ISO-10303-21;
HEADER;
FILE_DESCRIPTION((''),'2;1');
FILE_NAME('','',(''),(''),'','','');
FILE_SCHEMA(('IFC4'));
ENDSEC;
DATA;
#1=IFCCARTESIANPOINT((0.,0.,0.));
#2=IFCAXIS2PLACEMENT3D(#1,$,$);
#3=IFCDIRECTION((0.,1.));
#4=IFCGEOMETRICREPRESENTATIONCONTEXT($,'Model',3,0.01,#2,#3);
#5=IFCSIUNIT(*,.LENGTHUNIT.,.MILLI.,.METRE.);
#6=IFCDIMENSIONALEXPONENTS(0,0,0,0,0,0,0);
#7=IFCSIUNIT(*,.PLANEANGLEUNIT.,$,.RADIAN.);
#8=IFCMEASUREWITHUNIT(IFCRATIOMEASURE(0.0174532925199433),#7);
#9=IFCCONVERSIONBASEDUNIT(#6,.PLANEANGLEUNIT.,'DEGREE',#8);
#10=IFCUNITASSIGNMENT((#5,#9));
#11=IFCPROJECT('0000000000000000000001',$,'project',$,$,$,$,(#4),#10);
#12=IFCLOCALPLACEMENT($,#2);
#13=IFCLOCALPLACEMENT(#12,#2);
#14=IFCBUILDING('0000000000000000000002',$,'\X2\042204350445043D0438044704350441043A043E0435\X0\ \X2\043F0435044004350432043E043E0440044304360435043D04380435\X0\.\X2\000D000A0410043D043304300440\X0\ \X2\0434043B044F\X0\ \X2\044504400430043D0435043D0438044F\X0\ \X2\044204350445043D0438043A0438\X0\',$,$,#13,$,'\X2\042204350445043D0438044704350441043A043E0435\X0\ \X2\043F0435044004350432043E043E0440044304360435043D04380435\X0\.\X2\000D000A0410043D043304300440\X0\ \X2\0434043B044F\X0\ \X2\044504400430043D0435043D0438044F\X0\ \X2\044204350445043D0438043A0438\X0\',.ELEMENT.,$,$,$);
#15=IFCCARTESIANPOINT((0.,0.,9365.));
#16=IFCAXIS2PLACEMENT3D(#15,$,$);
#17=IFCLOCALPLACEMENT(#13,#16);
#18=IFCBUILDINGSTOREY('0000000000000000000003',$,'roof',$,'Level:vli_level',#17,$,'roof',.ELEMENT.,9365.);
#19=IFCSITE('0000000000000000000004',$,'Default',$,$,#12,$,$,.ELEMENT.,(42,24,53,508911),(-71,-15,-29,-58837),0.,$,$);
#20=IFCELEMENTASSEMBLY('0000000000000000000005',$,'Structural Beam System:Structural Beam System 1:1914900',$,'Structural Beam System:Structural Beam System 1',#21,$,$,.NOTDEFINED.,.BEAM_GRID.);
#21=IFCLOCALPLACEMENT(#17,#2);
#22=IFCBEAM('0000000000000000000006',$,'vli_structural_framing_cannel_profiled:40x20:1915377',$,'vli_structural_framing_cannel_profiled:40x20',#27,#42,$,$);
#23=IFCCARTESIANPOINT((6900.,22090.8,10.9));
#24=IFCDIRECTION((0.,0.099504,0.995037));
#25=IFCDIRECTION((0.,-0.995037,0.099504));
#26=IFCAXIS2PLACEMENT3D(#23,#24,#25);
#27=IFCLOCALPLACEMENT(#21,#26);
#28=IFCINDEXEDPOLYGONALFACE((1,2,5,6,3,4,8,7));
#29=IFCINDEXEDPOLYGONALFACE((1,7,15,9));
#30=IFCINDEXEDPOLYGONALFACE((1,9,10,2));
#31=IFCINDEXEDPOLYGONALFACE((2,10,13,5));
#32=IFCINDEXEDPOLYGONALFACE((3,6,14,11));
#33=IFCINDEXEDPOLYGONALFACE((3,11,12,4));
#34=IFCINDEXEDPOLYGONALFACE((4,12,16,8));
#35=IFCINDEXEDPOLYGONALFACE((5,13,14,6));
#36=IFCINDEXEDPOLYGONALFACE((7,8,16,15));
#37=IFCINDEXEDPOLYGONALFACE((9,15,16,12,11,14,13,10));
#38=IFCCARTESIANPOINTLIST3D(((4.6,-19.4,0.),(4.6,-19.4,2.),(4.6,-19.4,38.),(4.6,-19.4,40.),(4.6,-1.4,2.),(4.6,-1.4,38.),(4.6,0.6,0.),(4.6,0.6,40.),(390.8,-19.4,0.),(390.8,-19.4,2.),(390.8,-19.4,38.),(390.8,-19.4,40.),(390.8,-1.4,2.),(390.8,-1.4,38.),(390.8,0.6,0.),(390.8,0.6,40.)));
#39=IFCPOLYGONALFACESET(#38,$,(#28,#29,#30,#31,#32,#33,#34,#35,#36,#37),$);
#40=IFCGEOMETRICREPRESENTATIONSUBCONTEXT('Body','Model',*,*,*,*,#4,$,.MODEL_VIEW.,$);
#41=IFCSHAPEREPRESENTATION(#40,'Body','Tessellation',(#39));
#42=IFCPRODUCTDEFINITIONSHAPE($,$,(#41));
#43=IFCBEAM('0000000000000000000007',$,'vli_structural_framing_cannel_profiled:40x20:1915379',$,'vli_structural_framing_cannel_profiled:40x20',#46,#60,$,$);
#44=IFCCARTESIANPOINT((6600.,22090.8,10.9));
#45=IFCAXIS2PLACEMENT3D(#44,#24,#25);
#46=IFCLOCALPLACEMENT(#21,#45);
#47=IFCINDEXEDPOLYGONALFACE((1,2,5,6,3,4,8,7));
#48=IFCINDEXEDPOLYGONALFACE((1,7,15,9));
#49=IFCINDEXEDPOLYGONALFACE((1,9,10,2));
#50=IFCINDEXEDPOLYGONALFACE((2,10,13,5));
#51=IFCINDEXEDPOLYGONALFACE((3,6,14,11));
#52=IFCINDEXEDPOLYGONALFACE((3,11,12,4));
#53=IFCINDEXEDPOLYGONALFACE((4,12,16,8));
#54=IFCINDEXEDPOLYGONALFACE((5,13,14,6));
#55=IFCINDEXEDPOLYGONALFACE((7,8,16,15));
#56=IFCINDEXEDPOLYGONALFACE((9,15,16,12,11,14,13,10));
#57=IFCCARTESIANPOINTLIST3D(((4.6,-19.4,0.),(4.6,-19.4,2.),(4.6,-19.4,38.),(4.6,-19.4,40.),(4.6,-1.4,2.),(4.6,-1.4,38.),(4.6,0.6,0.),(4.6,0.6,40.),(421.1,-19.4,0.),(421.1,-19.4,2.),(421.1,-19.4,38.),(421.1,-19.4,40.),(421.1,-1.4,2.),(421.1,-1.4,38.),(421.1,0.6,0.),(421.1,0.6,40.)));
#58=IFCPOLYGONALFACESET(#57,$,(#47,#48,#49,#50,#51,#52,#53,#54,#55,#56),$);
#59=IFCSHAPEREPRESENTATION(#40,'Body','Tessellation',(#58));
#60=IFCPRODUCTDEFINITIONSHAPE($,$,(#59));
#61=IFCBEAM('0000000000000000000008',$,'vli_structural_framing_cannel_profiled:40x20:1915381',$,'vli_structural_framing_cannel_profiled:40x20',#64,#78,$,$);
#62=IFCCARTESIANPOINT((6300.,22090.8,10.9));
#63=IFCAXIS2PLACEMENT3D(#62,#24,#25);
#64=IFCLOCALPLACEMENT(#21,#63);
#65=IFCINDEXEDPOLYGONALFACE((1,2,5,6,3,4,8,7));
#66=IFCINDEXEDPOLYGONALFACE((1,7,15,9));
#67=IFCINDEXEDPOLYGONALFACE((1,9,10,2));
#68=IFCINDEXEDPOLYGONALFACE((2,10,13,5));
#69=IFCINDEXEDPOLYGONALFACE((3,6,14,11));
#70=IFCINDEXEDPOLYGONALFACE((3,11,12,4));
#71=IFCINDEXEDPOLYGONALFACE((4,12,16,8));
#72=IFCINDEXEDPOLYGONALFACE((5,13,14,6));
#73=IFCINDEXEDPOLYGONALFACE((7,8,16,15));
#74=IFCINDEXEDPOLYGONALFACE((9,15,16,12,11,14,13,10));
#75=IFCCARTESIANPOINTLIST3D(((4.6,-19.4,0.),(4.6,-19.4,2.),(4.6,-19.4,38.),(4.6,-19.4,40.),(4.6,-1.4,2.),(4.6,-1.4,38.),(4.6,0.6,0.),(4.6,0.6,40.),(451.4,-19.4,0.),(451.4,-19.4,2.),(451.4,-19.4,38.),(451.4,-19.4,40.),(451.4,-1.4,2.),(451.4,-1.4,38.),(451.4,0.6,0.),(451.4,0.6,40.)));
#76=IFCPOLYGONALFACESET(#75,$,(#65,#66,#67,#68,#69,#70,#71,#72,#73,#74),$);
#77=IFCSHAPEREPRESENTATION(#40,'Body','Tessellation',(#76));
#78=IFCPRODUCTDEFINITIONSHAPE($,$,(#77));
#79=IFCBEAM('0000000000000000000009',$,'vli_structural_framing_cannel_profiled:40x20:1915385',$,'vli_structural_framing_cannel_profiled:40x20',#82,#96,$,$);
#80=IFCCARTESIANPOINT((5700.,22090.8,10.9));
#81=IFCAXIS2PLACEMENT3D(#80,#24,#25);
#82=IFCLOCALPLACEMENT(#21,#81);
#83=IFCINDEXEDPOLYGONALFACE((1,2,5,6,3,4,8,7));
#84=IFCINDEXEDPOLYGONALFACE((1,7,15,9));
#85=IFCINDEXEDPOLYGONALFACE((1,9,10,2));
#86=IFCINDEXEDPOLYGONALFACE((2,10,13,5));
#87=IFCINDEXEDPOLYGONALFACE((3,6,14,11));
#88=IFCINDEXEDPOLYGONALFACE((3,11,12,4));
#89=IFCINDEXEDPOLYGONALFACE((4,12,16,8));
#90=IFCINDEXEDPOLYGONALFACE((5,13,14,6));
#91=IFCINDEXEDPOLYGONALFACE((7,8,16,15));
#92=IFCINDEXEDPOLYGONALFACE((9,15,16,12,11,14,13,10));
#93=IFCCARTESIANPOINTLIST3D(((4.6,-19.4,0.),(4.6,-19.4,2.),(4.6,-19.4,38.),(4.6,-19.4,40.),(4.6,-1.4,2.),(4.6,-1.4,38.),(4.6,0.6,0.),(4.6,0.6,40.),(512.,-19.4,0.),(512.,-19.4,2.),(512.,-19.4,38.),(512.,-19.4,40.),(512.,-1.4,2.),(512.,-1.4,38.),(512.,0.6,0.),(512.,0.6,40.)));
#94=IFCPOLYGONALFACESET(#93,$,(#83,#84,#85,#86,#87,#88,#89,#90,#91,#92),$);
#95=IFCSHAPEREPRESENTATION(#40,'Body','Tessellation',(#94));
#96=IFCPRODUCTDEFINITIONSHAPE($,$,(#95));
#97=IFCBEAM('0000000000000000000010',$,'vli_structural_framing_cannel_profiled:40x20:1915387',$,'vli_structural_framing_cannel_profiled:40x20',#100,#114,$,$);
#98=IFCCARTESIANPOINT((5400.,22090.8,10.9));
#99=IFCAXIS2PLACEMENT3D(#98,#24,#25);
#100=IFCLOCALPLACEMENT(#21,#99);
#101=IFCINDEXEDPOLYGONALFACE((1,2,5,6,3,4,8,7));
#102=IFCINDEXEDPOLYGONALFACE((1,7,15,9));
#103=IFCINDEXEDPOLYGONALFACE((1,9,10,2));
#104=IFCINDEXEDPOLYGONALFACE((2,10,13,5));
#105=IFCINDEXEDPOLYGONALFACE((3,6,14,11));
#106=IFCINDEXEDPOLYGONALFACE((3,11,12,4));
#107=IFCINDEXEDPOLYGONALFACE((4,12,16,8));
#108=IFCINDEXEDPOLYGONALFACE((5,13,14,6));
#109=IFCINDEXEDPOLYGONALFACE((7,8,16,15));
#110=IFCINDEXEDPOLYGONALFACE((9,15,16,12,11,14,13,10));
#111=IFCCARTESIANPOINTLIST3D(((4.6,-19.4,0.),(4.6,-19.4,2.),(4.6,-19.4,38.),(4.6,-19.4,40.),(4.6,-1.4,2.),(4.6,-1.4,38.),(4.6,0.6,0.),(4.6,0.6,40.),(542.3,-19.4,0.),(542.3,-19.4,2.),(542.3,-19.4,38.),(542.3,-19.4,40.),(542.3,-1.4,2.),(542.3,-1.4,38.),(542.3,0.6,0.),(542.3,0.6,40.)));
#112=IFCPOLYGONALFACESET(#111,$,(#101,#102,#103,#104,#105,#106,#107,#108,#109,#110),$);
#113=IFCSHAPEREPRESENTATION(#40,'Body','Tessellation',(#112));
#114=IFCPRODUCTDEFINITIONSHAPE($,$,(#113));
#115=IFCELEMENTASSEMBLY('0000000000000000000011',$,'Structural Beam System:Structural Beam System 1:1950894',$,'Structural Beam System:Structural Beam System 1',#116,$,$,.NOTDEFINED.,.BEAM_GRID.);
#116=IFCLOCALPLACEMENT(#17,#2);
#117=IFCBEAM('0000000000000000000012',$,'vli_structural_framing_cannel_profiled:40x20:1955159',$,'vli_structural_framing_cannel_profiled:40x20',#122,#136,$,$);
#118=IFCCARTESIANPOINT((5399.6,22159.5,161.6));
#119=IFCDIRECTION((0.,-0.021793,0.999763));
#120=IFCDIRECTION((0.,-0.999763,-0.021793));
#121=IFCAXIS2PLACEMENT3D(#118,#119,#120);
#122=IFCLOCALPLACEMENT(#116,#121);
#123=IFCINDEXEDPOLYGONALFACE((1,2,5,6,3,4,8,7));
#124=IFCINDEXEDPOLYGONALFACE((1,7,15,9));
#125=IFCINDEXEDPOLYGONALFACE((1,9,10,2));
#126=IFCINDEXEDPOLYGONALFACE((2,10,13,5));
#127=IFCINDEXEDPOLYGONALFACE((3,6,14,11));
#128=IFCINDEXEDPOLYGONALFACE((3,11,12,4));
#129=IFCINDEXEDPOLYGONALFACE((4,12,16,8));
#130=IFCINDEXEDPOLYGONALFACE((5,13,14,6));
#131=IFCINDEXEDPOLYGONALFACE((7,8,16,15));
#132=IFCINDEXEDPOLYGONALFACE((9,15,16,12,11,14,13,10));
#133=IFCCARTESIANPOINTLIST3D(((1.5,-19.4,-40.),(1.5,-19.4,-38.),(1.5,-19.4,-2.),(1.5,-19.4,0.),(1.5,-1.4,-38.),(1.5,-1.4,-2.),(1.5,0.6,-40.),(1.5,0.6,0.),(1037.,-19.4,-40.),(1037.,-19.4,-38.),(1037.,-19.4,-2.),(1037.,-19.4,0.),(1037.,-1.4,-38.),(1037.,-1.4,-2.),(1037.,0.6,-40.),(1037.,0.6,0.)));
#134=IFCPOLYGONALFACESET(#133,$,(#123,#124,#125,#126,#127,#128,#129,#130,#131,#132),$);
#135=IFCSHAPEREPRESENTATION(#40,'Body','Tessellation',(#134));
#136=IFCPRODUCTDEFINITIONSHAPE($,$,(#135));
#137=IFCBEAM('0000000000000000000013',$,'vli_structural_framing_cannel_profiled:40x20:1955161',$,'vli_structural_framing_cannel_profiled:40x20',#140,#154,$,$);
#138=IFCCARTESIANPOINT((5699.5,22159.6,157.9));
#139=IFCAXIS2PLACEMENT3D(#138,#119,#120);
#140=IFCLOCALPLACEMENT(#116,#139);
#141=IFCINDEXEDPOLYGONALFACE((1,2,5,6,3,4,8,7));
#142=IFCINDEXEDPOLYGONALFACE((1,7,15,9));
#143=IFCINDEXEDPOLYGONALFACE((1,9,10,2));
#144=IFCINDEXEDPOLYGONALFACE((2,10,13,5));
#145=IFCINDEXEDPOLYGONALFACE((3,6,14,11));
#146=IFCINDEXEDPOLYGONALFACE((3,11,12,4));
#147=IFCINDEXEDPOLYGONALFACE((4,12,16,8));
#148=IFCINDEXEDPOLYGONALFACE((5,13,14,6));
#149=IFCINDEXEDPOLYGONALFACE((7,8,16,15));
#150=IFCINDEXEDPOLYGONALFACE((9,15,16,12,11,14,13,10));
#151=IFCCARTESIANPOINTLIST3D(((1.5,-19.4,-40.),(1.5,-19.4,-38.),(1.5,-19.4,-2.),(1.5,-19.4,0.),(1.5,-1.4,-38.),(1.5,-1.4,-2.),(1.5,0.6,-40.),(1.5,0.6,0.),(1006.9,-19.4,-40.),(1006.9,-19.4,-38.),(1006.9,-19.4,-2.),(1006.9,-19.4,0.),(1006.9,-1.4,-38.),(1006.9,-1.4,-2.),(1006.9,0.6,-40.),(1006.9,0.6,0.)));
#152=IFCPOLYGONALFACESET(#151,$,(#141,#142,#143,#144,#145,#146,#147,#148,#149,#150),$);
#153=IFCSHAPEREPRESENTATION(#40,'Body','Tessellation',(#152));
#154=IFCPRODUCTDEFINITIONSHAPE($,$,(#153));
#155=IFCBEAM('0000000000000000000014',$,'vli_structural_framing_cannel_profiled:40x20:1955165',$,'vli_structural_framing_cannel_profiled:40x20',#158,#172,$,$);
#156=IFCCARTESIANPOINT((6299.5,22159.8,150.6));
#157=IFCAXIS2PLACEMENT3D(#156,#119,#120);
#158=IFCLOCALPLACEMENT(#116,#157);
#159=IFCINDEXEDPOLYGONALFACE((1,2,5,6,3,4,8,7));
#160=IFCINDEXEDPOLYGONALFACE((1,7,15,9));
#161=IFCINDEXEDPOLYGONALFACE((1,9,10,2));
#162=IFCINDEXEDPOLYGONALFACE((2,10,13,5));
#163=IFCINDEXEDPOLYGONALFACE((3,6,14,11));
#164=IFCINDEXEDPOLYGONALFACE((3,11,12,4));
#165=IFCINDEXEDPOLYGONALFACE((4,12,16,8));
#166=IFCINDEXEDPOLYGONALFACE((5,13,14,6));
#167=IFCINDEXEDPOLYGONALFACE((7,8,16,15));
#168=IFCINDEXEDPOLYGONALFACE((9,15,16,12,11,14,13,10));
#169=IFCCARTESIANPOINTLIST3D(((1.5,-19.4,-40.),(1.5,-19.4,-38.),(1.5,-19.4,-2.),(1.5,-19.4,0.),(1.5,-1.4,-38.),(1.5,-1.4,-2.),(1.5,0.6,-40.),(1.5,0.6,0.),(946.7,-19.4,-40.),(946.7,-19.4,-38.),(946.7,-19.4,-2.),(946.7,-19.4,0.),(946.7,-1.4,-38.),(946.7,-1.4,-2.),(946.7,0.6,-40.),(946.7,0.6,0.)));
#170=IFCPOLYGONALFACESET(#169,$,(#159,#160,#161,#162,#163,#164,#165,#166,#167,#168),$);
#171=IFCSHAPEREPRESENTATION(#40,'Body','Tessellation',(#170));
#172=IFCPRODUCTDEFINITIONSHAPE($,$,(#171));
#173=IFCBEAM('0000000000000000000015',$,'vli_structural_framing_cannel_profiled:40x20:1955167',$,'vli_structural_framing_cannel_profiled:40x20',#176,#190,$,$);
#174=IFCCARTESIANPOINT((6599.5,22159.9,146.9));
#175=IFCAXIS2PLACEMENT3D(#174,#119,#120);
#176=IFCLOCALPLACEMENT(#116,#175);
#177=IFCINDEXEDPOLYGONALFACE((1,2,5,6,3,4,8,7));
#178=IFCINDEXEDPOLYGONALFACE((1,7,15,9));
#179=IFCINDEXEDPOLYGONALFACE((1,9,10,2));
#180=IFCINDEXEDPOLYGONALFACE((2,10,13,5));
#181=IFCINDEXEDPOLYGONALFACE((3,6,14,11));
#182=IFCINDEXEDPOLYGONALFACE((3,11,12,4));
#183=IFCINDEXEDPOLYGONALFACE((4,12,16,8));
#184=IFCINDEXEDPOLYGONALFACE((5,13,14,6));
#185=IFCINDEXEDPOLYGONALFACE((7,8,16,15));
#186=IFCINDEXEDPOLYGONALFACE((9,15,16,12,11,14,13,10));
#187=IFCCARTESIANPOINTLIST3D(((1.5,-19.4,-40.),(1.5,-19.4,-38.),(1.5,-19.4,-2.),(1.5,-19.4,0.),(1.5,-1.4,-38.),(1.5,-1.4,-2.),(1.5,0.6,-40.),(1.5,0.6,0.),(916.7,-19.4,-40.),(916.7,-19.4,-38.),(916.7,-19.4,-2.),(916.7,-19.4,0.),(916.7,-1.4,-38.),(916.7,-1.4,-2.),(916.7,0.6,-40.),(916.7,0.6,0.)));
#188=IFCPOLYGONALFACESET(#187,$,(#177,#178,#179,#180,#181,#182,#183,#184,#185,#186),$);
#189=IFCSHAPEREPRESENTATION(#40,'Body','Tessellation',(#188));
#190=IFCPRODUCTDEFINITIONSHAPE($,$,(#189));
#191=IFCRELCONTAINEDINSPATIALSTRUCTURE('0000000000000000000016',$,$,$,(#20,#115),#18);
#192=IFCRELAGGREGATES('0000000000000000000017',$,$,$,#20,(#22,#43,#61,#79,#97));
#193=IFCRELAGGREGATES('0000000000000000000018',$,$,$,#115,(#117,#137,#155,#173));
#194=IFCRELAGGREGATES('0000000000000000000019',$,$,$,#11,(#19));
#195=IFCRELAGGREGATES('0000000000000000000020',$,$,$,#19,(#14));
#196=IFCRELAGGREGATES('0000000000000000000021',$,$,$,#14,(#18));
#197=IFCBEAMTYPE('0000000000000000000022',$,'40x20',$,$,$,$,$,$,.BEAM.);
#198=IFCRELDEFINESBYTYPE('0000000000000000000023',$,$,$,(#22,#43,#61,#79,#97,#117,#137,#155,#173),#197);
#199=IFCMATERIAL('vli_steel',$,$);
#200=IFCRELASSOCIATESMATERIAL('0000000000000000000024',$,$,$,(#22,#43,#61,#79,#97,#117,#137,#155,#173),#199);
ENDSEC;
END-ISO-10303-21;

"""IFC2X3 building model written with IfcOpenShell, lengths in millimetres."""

from ifc_helpers import new_model, entity, si_unit, converted_unit, direction, frame, origin, place, context, subcontext, project, spatial, polyline, outline, extrude, material, type_object, element, aggregate, save


model = new_model("IFC2X3")

# Units and contexts
model_context = context("Model", 3, precision=0.01, world=origin(), true_north=direction((0.0, 1.0)))
body_context = subcontext(model_context, "Body", "Model", "MODEL_VIEW")
ifc_project = project(units=[si_unit("LENGTHUNIT", "METRE", prefix="MILLI"), converted_unit("PLANEANGLEUNIT", "DEGREE", entity("IfcRatioMeasure", 0.0174532925199433), si_unit("PLANEANGLEUNIT", "RADIAN"), dimensions=[0, 0, 0, 0, 0, 0, 0])], contexts=[model_context])

# Site, building, storey
site_placement = place(None, origin())
site = spatial("IfcSite", under=ifc_project, at=site_placement, Name="Default", CompositionType="ELEMENT", RefLatitude=(42, 24, 53, 508911), RefLongitude=(-71, -15, -29, -58837), RefElevation=0.0)
building_placement = place(site_placement, origin())
building = spatial("IfcBuilding", under=site, at=building_placement, Name="Техническое перевооружение.\r\nАнгар для хранения техники", LongName="Техническое перевооружение.\r\nАнгар для хранения техники", CompositionType="ELEMENT")
storey_placement = place(building_placement, frame((0.0, 0.0, 9365.0)))
storey = spatial("IfcBuildingStorey", under=building, at=storey_placement, Name="roof", ObjectType="Level:vli_level", LongName="roof", CompositionType="ELEMENT", Elevation=9365.0)

# Element assemblies, beams
assembly_1_placement = place(storey_placement, origin())
assembly_1 = element("IfcElementAssembly", 1, at=assembly_1_placement, inside=storey, Name="Structural Beam System:Structural Beam System 1:1914900", ObjectType="Structural Beam System:Structural Beam System 1", AssemblyPlace="NOTDEFINED", PredefinedType="BEAM_GRID")
ifc_material = material(Name="vli_steel")
beam_type = type_object("IfcBeamType", Name="40x20", PredefinedType="BEAM")
beam_1_placement = place(assembly_1_placement, frame((6900.0, 22090.8, 10.9), z_axis=(0.0, 0.099504, 0.995037), x_axis=(0.0, -0.995037, 0.099504)))
beam_1 = element("IfcBeam", 2, at=beam_1_placement, type_object=beam_type, material=ifc_material, Name="vli_structural_framing_cannel_profiled:40x20:1915377", ObjectType="vli_structural_framing_cannel_profiled:40x20", context=body_context, shape_type="SweptSolid", body=[
    extrude(outline(polyline([(-20.0, -9.5), (-18.0, -9.5), (-18.0, 8.5), (18.0, 8.5), (18.0, -9.5), (20.0, -9.5), (20.0, 10.5), (-20.0, 10.5), (-20.0, -9.5)])), frame((4.6, -9.9, 20.0), z_axis=(1.0, 0.0, 0.0), x_axis=(0.0, 0.0, -1.0)), (0.0, 0.0, 1.0), 386.2),
])
beam_2_placement = place(assembly_1_placement, frame((6600.0, 22090.8, 10.9), z_axis=(0.0, 0.099504, 0.995037), x_axis=(0.0, -0.995037, 0.099504)))
beam_2 = element("IfcBeam", 3, at=beam_2_placement, type_object=beam_type, material=ifc_material, Name="vli_structural_framing_cannel_profiled:40x20:1915379", ObjectType="vli_structural_framing_cannel_profiled:40x20", context=body_context, shape_type="SweptSolid", body=[
    extrude(outline(polyline([(-20.0, -9.5), (-18.0, -9.5), (-18.0, 8.5), (18.0, 8.5), (18.0, -9.5), (20.0, -9.5), (20.0, 10.5), (-20.0, 10.5), (-20.0, -9.5)])), frame((4.6, -9.9, 20.0), z_axis=(1.0, 0.0, 0.0), x_axis=(0.0, 0.0, -1.0)), (0.0, 0.0, 1.0), 416.5),
])
beam_3_placement = place(assembly_1_placement, frame((6300.0, 22090.8, 10.9), z_axis=(0.0, 0.099504, 0.995037), x_axis=(0.0, -0.995037, 0.099504)))
beam_3 = element("IfcBeam", 4, at=beam_3_placement, type_object=beam_type, material=ifc_material, Name="vli_structural_framing_cannel_profiled:40x20:1915381", ObjectType="vli_structural_framing_cannel_profiled:40x20", context=body_context, shape_type="SweptSolid", body=[
    extrude(outline(polyline([(-20.0, -9.5), (-18.0, -9.5), (-18.0, 8.5), (18.0, 8.5), (18.0, -9.5), (20.0, -9.5), (20.0, 10.5), (-20.0, 10.5), (-20.0, -9.5)])), frame((4.6, -9.9, 20.0), z_axis=(1.0, 0.0, 0.0), x_axis=(0.0, 0.0, -1.0)), (0.0, 0.0, 1.0), 446.8),
])
beam_4_placement = place(assembly_1_placement, frame((5700.0, 22090.8, 10.9), z_axis=(0.0, 0.099504, 0.995037), x_axis=(0.0, -0.995037, 0.099504)))
beam_4 = element("IfcBeam", 5, at=beam_4_placement, type_object=beam_type, material=ifc_material, Name="vli_structural_framing_cannel_profiled:40x20:1915385", ObjectType="vli_structural_framing_cannel_profiled:40x20", context=body_context, shape_type="SweptSolid", body=[
    extrude(outline(polyline([(-20.0, -9.5), (-18.0, -9.5), (-18.0, 8.5), (18.0, 8.5), (18.0, -9.5), (20.0, -9.5), (20.0, 10.5), (-20.0, 10.5), (-20.0, -9.5)])), frame((4.6, -9.9, 20.0), z_axis=(1.0, 0.0, 0.0), x_axis=(0.0, 0.0, -1.0)), (0.0, 0.0, 1.0), 507.4),
])
beam_5_placement = place(assembly_1_placement, frame((5400.0, 22090.8, 10.9), z_axis=(0.0, 0.099504, 0.995037), x_axis=(0.0, -0.995037, 0.099504)))
beam_5 = element("IfcBeam", 6, at=beam_5_placement, type_object=beam_type, material=ifc_material, Name="vli_structural_framing_cannel_profiled:40x20:1915387", ObjectType="vli_structural_framing_cannel_profiled:40x20", context=body_context, shape_type="SweptSolid", body=[
    extrude(outline(polyline([(-20.0, -9.5), (-18.0, -9.5), (-18.0, 8.5), (18.0, 8.5), (18.0, -9.5), (20.0, -9.5), (20.0, 10.5), (-20.0, 10.5), (-20.0, -9.5)])), frame((4.6, -9.9, 20.0), z_axis=(1.0, 0.0, 0.0), x_axis=(0.0, 0.0, -1.0)), (0.0, 0.0, 1.0), 537.7),
])
aggregate(assembly_1, [beam_1, beam_2, beam_3, beam_4, beam_5])
assembly_2_placement = place(storey_placement, origin())
assembly_2 = element("IfcElementAssembly", 7, at=assembly_2_placement, inside=storey, Name="Structural Beam System:Structural Beam System 1:1950894", ObjectType="Structural Beam System:Structural Beam System 1", AssemblyPlace="NOTDEFINED", PredefinedType="BEAM_GRID")
beam_6_placement = place(assembly_2_placement, frame((5399.6, 22159.5, 161.6), z_axis=(0.0, -0.021793, 0.999763), x_axis=(0.0, -0.999763, -0.021793)))
beam_6 = element("IfcBeam", 8, at=beam_6_placement, type_object=beam_type, material=ifc_material, Name="vli_structural_framing_cannel_profiled:40x20:1955159", ObjectType="vli_structural_framing_cannel_profiled:40x20", context=body_context, shape_type="SweptSolid", body=[
    extrude(outline(polyline([(-20.0, -9.5), (-18.0, -9.5), (-18.0, 8.5), (18.0, 8.5), (18.0, -9.5), (20.0, -9.5), (20.0, 10.5), (-20.0, 10.5), (-20.0, -9.5)])), frame((1.5, -9.9, -20.0), z_axis=(1.0, 0.0, 0.0), x_axis=(0.0, 0.0, -1.0)), (0.0, 0.0, 1.0), 1035.5),
])
beam_7_placement = place(assembly_2_placement, frame((5699.5, 22159.6, 157.9), z_axis=(0.0, -0.021793, 0.999763), x_axis=(0.0, -0.999763, -0.021793)))
beam_7 = element("IfcBeam", 9, at=beam_7_placement, type_object=beam_type, material=ifc_material, Name="vli_structural_framing_cannel_profiled:40x20:1955161", ObjectType="vli_structural_framing_cannel_profiled:40x20", context=body_context, shape_type="SweptSolid", body=[
    extrude(outline(polyline([(-20.0, -9.5), (-18.0, -9.5), (-18.0, 8.5), (18.0, 8.5), (18.0, -9.5), (20.0, -9.5), (20.0, 10.5), (-20.0, 10.5), (-20.0, -9.5)])), frame((1.5, -9.9, -20.0), z_axis=(1.0, 0.0, 0.0), x_axis=(0.0, 0.0, -1.0)), (0.0, 0.0, 1.0), 1005.4),
])
beam_8_placement = place(assembly_2_placement, frame((6299.5, 22159.8, 150.6), z_axis=(0.0, -0.021793, 0.999763), x_axis=(0.0, -0.999763, -0.021793)))
beam_8 = element("IfcBeam", 10, at=beam_8_placement, type_object=beam_type, material=ifc_material, Name="vli_structural_framing_cannel_profiled:40x20:1955165", ObjectType="vli_structural_framing_cannel_profiled:40x20", context=body_context, shape_type="SweptSolid", body=[
    extrude(outline(polyline([(-20.0, -9.5), (-18.0, -9.5), (-18.0, 8.5), (18.0, 8.5), (18.0, -9.5), (20.0, -9.5), (20.0, 10.5), (-20.0, 10.5), (-20.0, -9.5)])), frame((1.5, -9.9, -20.0), z_axis=(1.0, 0.0, 0.0), x_axis=(0.0, 0.0, -1.0)), (0.0, 0.0, 1.0), 945.3),
])
beam_9_placement = place(assembly_2_placement, frame((6599.5, 22159.9, 146.9), z_axis=(0.0, -0.021793, 0.999763), x_axis=(0.0, -0.999763, -0.021793)))
beam_9 = element("IfcBeam", 11, at=beam_9_placement, type_object=beam_type, material=ifc_material, Name="vli_structural_framing_cannel_profiled:40x20:1955167", ObjectType="vli_structural_framing_cannel_profiled:40x20", context=body_context, shape_type="SweptSolid", body=[
    extrude(outline(polyline([(-20.0, -9.5), (-18.0, -9.5), (-18.0, 8.5), (18.0, 8.5), (18.0, -9.5), (20.0, -9.5), (20.0, 10.5), (-20.0, 10.5), (-20.0, -9.5)])), frame((1.5, -9.9, -20.0), z_axis=(1.0, 0.0, 0.0), x_axis=(0.0, 0.0, -1.0)), (0.0, 0.0, 1.0), 915.2),
])

aggregate(assembly_2, [beam_6, beam_7, beam_8, beam_9])

save(model, "model.ifc")
